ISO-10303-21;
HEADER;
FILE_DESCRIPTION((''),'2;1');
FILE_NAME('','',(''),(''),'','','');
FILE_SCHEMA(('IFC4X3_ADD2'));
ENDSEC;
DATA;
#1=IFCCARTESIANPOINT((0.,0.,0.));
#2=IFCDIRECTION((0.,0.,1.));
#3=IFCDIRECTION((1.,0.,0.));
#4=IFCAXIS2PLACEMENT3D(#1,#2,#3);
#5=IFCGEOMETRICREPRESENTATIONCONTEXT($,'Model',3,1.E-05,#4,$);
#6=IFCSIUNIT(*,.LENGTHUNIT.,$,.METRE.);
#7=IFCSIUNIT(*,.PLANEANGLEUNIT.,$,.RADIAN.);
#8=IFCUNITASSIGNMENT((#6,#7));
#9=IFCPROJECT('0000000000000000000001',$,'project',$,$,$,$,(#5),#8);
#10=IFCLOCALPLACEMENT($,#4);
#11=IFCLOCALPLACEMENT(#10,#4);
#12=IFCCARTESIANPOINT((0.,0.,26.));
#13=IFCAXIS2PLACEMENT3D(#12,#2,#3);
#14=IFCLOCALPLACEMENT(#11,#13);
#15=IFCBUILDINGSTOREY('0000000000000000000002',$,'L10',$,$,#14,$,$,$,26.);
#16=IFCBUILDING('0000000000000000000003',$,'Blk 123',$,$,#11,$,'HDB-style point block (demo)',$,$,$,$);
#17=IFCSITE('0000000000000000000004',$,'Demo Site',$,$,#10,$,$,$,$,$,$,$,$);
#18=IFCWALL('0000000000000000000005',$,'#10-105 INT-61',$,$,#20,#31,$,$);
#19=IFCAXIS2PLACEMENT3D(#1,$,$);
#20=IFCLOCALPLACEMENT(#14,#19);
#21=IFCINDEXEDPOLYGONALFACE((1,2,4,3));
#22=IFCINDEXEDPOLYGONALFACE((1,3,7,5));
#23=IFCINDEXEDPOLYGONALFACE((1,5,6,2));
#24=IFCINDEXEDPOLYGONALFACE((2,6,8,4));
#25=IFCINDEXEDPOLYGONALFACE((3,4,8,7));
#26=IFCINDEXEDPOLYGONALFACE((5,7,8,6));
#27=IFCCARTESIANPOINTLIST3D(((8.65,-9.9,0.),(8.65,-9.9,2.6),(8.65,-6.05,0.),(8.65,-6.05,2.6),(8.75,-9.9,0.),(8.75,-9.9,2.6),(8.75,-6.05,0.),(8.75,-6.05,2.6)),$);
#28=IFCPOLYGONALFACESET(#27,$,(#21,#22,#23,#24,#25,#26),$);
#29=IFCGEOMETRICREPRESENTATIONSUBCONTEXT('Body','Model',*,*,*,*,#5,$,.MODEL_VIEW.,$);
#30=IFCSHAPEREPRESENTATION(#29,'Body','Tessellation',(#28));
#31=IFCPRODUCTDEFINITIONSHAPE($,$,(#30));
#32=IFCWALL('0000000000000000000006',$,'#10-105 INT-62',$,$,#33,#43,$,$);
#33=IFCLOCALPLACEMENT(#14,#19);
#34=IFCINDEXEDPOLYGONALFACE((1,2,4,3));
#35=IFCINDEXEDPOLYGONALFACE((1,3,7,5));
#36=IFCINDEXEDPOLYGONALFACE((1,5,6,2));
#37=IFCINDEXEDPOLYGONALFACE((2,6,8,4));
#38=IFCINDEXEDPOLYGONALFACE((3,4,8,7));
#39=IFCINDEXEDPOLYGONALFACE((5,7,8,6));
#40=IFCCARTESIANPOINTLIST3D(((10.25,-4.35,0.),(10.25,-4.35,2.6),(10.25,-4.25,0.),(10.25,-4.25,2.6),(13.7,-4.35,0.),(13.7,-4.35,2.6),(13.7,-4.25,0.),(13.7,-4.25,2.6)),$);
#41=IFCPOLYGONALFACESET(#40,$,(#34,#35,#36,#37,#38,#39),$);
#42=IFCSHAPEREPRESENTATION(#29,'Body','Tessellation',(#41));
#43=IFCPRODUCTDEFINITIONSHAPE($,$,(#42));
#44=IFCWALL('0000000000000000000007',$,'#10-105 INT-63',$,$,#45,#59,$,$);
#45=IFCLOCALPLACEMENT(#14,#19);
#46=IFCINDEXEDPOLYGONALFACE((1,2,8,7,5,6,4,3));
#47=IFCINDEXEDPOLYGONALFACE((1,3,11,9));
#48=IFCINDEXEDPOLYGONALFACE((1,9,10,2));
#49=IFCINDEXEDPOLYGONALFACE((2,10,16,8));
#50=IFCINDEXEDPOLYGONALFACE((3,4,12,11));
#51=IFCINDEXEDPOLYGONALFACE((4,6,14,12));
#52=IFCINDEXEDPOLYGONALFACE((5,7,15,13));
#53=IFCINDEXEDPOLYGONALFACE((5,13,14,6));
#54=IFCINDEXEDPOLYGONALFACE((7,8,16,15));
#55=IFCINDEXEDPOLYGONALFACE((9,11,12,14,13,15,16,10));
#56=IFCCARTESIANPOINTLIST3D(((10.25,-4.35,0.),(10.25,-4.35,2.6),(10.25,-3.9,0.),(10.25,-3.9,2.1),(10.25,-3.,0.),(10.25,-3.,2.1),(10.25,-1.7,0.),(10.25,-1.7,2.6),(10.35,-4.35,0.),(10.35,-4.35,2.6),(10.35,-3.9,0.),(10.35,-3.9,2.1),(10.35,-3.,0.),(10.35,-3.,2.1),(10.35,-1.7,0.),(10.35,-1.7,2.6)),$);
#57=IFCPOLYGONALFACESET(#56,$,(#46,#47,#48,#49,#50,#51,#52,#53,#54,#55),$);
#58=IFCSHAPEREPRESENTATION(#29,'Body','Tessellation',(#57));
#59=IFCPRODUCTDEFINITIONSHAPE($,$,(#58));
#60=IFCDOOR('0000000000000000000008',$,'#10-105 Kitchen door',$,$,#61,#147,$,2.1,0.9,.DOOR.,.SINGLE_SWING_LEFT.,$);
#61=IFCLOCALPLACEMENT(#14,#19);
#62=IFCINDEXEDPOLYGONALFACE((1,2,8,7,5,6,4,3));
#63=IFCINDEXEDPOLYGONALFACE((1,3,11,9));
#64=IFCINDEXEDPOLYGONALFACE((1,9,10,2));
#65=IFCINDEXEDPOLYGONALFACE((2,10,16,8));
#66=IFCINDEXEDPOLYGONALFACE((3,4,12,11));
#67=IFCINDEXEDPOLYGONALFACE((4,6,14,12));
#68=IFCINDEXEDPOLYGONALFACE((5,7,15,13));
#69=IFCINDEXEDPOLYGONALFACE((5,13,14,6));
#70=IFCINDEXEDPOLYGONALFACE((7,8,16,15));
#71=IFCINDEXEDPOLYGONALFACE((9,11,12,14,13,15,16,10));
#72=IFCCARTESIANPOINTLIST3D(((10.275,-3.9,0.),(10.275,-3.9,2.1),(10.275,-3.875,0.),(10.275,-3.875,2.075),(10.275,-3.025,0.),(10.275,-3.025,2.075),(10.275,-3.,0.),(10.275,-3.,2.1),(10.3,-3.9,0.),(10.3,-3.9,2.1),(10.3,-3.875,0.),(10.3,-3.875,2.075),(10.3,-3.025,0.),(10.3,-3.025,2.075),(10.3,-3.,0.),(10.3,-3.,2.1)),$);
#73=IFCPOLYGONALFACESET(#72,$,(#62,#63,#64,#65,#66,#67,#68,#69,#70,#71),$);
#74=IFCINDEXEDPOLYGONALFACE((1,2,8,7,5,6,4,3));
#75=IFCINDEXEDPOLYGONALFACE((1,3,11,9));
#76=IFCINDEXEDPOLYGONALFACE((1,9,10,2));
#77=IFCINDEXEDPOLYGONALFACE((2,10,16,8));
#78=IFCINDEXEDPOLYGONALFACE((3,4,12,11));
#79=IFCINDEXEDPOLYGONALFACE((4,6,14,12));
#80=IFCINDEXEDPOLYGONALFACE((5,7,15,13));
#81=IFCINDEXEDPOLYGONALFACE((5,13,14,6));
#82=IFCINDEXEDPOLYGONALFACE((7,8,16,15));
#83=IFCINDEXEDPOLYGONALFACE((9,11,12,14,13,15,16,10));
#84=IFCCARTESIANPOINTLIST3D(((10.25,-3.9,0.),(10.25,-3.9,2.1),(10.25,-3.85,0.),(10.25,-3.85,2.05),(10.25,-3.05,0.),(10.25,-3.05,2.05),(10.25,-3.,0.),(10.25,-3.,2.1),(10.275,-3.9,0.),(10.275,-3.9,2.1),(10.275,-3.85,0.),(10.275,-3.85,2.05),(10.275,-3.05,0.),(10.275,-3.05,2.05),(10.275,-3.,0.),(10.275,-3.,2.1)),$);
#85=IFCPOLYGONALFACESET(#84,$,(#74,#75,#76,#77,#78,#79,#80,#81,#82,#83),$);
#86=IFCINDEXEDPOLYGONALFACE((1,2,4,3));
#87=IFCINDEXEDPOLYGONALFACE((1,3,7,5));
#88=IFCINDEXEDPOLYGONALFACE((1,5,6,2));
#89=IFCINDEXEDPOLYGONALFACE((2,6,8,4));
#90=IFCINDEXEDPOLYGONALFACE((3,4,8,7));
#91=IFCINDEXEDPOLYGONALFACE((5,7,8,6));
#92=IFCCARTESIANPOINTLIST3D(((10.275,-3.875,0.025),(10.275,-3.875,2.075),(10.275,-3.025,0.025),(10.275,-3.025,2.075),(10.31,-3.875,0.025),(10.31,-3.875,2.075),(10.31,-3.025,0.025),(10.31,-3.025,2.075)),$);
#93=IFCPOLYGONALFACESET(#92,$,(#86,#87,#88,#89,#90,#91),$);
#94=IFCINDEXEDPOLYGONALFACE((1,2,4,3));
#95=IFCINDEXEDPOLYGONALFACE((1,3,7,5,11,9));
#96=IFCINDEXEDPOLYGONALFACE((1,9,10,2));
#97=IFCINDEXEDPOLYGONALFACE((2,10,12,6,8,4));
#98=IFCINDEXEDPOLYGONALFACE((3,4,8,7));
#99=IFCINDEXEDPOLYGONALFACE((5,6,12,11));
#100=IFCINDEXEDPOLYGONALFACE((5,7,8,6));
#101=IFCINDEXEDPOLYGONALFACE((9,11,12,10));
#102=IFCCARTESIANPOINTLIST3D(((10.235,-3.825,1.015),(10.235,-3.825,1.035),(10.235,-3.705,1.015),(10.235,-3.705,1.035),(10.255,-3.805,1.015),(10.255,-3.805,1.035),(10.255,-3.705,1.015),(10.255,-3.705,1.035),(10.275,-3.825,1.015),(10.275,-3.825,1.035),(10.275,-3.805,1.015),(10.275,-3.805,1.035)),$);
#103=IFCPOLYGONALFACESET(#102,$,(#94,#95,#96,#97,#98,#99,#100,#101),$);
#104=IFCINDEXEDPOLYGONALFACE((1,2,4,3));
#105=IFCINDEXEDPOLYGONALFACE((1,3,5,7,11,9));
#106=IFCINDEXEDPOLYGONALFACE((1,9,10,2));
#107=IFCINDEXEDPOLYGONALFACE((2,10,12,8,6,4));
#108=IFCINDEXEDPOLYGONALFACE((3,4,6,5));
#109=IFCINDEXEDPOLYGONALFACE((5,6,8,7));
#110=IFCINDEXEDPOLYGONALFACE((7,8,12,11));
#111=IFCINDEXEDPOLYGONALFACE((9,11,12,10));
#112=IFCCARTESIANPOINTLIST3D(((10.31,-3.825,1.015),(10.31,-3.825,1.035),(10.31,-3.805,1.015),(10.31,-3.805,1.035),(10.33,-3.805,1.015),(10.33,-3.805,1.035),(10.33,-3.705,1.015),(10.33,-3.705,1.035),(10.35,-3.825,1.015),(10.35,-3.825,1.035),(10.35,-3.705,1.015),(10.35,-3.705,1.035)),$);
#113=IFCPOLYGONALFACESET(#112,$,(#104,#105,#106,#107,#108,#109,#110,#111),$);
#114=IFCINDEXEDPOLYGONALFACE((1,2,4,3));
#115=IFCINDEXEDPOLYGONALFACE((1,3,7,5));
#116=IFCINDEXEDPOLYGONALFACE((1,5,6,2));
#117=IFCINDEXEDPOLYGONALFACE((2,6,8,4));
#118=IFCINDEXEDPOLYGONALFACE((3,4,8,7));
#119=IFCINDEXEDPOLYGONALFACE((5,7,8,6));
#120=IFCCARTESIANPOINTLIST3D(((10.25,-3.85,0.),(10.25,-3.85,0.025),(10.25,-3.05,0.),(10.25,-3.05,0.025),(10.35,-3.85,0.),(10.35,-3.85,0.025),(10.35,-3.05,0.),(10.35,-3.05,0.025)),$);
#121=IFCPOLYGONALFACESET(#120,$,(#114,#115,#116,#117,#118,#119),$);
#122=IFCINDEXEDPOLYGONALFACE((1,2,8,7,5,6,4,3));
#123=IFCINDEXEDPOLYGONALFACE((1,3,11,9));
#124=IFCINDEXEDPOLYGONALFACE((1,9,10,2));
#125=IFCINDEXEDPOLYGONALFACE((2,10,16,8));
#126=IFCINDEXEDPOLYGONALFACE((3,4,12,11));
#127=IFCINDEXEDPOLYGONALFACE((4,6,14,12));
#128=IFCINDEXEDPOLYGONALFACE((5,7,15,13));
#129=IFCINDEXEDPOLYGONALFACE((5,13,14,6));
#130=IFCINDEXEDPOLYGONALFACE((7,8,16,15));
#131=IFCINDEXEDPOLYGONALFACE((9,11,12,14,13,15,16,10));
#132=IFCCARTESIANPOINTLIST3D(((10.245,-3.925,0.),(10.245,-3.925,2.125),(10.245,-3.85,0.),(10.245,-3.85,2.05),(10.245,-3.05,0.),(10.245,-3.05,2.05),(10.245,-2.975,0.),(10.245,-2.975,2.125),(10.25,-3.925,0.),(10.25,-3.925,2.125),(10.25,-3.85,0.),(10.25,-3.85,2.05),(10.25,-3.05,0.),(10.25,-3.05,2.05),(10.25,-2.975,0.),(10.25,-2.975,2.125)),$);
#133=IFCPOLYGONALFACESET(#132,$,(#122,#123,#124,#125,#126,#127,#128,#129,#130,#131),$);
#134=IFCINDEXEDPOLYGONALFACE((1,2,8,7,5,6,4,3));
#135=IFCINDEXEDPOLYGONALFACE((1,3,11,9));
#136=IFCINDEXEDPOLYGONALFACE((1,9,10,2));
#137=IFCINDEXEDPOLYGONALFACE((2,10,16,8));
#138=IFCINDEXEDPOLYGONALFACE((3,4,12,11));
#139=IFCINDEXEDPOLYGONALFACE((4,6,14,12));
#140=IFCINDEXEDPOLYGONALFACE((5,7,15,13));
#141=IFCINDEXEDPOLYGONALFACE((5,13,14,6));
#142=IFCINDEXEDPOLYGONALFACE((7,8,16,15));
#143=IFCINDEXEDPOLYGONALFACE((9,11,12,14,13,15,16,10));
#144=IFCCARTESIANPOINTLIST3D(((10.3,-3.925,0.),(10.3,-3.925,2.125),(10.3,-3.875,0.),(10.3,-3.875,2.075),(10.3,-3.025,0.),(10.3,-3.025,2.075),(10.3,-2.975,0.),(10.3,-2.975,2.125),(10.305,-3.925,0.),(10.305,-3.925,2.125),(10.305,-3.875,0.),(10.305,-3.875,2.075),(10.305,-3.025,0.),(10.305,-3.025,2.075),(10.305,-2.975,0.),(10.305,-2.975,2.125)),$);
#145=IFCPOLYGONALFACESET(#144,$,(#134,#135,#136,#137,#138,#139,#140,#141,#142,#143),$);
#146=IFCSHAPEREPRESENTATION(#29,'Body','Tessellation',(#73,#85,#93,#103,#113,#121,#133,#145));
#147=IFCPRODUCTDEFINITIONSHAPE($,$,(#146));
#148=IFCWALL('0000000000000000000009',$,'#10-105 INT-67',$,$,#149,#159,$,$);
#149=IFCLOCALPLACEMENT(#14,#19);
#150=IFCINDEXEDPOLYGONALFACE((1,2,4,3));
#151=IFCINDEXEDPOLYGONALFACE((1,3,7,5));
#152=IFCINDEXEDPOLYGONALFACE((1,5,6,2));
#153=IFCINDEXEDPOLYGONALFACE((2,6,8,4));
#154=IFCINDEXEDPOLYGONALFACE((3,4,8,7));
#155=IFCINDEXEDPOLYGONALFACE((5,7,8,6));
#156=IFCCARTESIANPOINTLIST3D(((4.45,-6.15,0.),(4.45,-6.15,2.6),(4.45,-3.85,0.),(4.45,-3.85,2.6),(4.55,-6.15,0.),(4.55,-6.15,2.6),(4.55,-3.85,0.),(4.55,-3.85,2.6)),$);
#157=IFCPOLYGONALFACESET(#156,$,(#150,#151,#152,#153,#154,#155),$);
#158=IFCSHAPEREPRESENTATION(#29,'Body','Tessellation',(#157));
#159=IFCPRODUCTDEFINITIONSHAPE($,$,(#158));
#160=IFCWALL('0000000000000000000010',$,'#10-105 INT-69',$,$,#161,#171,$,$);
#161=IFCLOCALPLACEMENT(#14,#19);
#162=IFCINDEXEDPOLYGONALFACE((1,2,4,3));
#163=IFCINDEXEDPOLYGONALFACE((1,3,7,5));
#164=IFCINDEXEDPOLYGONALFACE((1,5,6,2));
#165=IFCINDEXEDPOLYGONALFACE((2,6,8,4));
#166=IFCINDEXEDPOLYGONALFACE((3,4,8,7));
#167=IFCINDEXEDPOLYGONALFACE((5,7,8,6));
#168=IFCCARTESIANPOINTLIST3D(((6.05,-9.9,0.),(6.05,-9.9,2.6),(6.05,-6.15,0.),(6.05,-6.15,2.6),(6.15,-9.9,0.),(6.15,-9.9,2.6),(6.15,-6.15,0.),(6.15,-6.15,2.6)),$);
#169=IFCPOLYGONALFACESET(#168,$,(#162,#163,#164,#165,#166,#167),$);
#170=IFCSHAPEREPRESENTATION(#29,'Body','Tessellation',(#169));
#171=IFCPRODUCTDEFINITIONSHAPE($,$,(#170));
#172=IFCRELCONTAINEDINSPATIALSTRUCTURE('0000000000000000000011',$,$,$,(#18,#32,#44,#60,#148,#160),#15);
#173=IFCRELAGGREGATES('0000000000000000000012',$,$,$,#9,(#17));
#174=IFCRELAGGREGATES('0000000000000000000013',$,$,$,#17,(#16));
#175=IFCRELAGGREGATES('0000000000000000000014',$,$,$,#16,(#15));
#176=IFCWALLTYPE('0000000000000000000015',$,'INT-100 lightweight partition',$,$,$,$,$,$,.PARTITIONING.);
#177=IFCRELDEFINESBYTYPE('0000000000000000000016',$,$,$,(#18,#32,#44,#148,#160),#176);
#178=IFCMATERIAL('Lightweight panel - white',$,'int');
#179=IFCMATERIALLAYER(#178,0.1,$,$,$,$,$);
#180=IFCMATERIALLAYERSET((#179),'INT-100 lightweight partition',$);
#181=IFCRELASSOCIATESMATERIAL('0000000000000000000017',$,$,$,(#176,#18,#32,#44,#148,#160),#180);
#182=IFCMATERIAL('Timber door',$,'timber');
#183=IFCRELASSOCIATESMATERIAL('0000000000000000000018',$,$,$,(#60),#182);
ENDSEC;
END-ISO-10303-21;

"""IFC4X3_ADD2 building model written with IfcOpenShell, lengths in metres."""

from ifc_helpers import new_model, si_unit, frame, origin_with_axes, place, context, subcontext, project, spatial, line, indexed_curve, outline, extrude, material, layer, layer_set, layer_usage, type_object, element, fill, save


model = new_model("IFC4X3_ADD2")

# Units and contexts
model_context = context("Model", 3, precision=1e-05, world=origin_with_axes())
body_context = subcontext(model_context, "Body", "Model", "MODEL_VIEW")
ifc_project = project(units=[si_unit("LENGTHUNIT", "METRE"), si_unit("PLANEANGLEUNIT", "RADIAN")], contexts=[model_context])

# Site, building, storey
site_placement = place(None, origin_with_axes())
site = spatial("IfcSite", under=ifc_project, at=site_placement, Name="Demo Site")
building_placement = place(site_placement, origin_with_axes())
building = spatial("IfcBuilding", under=site, at=building_placement, Name="Blk 123", LongName="HDB-style point block (demo)")
storey_placement = place(building_placement, frame((0.0, 0.0, 26.0), z_axis=(0.0, 0.0, 1.0), x_axis=(1.0, 0.0, 0.0)))
storey = spatial("IfcBuildingStorey", under=building, at=storey_placement, Name="L10", Elevation=26.0)

# Walls
ifc_material_1 = material(Name="Lightweight panel - white", Category="int")
ifc_layer_1 = layer(ifc_material_1, 0.1)
ifc_layer_set_1 = layer_set([ifc_layer_1], Name="INT-100 lightweight partition")
ifc_layer_usage_1 = layer_usage(ifc_layer_set_1, "AXIS2", "POSITIVE", -0.05)
wall_type_1 = type_object("IfcWallType", Name="INT-100 lightweight partition", PredefinedType="PARTITIONING", material=ifc_layer_set_1)
wall_1_placement = place(storey_placement, frame((8.7, -6.05, 0.0), z_axis=(0.0, 0.0, 1.0), x_axis=(0.0, -1.0, 0.0)))
element("IfcWall", 1, at=wall_1_placement, inside=storey, type_object=wall_type_1, material=ifc_layer_usage_1, Name="#10-105 INT-61", context=body_context, shape_type="SweptSolid", body=[
    extrude(outline(indexed_curve([(0.0, 0.0), (0.0, 0.1), (3.85, 0.1), (3.85, 0.0), (0.0, 0.0)], self_intersect=False)), frame((0.0, -0.05, 0.0), z_axis=(0.0, 0.0, 1.0), x_axis=(1.0, 0.0, 0.0)), (0.0, 0.0, 1.0), 2.6),
])
wall_2_placement = place(storey_placement, frame((10.25, -4.3, 0.0), z_axis=(0.0, 0.0, 1.0), x_axis=(1.0, 0.0, 0.0)))
element("IfcWall", 2, at=wall_2_placement, inside=storey, type_object=wall_type_1, material=ifc_layer_usage_1, Name="#10-105 INT-62", context=body_context, shape_type="SweptSolid", body=[
    extrude(outline(indexed_curve([(0.0, 0.0), (0.0, 0.1), (3.45, 0.1), (3.45, 0.0), (0.0, 0.0)], self_intersect=False)), frame((0.0, -0.05, 0.0), z_axis=(0.0, 0.0, 1.0), x_axis=(1.0, 0.0, 0.0)), (0.0, 0.0, 1.0), 2.6),
])

# Wall, opening, door
wall_3_placement = place(storey_placement, frame((10.3, -1.7, 0.0), z_axis=(0.0, 0.0, 1.0), x_axis=(0.0, -1.0, 0.0)))
wall_3 = element("IfcWall", 3, at=wall_3_placement, inside=storey, type_object=wall_type_1, material=ifc_layer_usage_1, Name="#10-105 INT-63", context=body_context, shape_type="SweptSolid", body=[
    extrude(outline(indexed_curve([(0.0, 0.0), (0.0, 0.1), (2.65, 0.1), (2.65, 0.0), (0.0, 0.0)], self_intersect=False)), frame((0.0, -0.05, 0.0), z_axis=(0.0, 0.0, 1.0), x_axis=(1.0, 0.0, 0.0)), (0.0, 0.0, 1.0), 2.6),
])
opening_1_placement = place(wall_3_placement, frame((1.3, -0.15, 0.0), z_axis=(0.0, 0.0, 1.0), x_axis=(1.0, 0.0, 0.0)))
opening_1 = element("IfcOpeningElement", 4, at=opening_1_placement, cuts=wall_3, context=body_context, shape_type="SweptSolid", body=[
    extrude(outline(indexed_curve([(0.0, 0.0), (0.0, 0.3), (0.9, 0.3), (0.9, 0.0), (0.0, 0.0)], self_intersect=False)), origin_with_axes(), (0.0, 0.0, 1.0), 2.1),
])
ifc_material_2 = material(Name="Timber door", Category="timber")
door_1_placement = place(opening_1_placement, frame((0.0, 0.1, 0.0), z_axis=(0.0, 0.0, 1.0), x_axis=(1.0, 0.0, 0.0)))
door_1 = element("IfcDoor", 5, at=door_1_placement, inside=storey, material=ifc_material_2, Name="#10-105 Kitchen door", OperationType="SINGLE_SWING_LEFT", OverallHeight=2.1, OverallWidth=0.9, PredefinedType="DOOR", context=body_context, shape_type="SweptSolid", body=[
    extrude(outline(indexed_curve([(0.0, 0.0), (0.0, 2.1), (0.9, 2.1), (0.9, 0.0), (0.875, 0.0), (0.875, 2.075), (0.025, 2.075), (0.025, 0.0)], segments=[line(1, 2, 3, 4, 5, 6, 7, 8, 1)])), frame((0.0, 0.025, 0.0), z_axis=(0.0, -1.0, 0.0), x_axis=(1.0, 0.0, 0.0)), (0.0, 0.0, -1.0), 0.025),
    extrude(outline(indexed_curve([(0.0, 0.0), (0.0, 2.1), (0.9, 2.1), (0.9, 0.0), (0.85, 0.0), (0.85, 2.05), (0.05, 2.05), (0.05, 0.0)], segments=[line(1, 2, 3, 4, 5, 6, 7, 8, 1)])), frame((0.0, 0.0, 0.0), z_axis=(0.0, -1.0, 0.0), x_axis=(1.0, 0.0, 0.0)), (0.0, 0.0, -1.0), 0.025),
    extrude(outline(indexed_curve([(0.0, 0.0), (0.85, 0.0), (0.85, 0.035), (0.0, 0.035)], segments=[line(1, 2, 3, 4, 1)])), frame((0.025, 0.025, 0.025), z_axis=(0.0, 0.0, 1.0), x_axis=(1.0, 0.0, 0.0)), (0.0, 0.0, 1.0), 2.05),
    extrude(outline(indexed_curve([(0.0, 0.0), (0.0, -0.04), (-0.12, -0.04), (-0.12, -0.02), (-0.02, -0.02), (-0.02, 0.0)], segments=[line(1, 2, 3, 4, 5, 6, 1)])), frame((0.825, 0.025, 1.015), z_axis=(0.0, 0.0, 1.0), x_axis=(1.0, 0.0, 0.0)), (0.0, 0.0, 1.0), 0.02),
    extrude(outline(indexed_curve([(0.0, 0.0), (0.0, 0.04), (-0.12, 0.04), (-0.12, 0.02), (-0.02, 0.02), (-0.02, 0.0)], segments=[line(1, 2, 3, 4, 5, 6, 1)])), frame((0.825, 0.06, 1.015), z_axis=(0.0, 0.0, 1.0), x_axis=(1.0, 0.0, 0.0)), (0.0, 0.0, 1.0), 0.02),
    extrude(outline(indexed_curve([(0.0, 0.0), (0.8, 0.0), (0.8, 0.1), (0.0, 0.1)], segments=[line(1, 2, 3, 4, 1)])), frame((0.05, 0.0, 0.0), z_axis=(0.0, 0.0, 1.0), x_axis=(1.0, 0.0, 0.0)), (0.0, 0.0, 1.0), 0.025),
    extrude(outline(indexed_curve([(0.0, 0.0), (0.0, 2.125), (0.95, 2.125), (0.95, 0.0), (0.875, 0.0), (0.875, 2.05), (0.075, 2.05), (0.075, 0.0)], segments=[line(1, 2, 3, 4, 5, 6, 7, 8, 1)])), frame((-0.025, -0.005, 0.0), z_axis=(0.0, -1.0, 0.0), x_axis=(1.0, 0.0, 0.0)), (0.0, 0.0, -1.0), 0.005),
    extrude(outline(indexed_curve([(0.0, 0.0), (0.0, 2.125), (0.95, 2.125), (0.95, 0.0), (0.9, 0.0), (0.9, 2.075), (0.05, 2.075), (0.05, 0.0)], segments=[line(1, 2, 3, 4, 5, 6, 7, 8, 1)])), frame((-0.025, 0.05, 0.0), z_axis=(0.0, -1.0, 0.0), x_axis=(1.0, 0.0, 0.0)), (0.0, 0.0, -1.0), 0.005),
])
fill(opening_1, door_1)

# Walls
wall_4_placement = place(storey_placement, frame((4.5, -3.85, 0.0), z_axis=(0.0, 0.0, 1.0), x_axis=(0.0, -1.0, 0.0)))
element("IfcWall", 6, at=wall_4_placement, inside=storey, type_object=wall_type_1, material=ifc_layer_usage_1, Name="#10-105 INT-67", context=body_context, shape_type="SweptSolid", body=[
    extrude(outline(indexed_curve([(0.0, 0.0), (0.0, 0.1), (2.3, 0.1), (2.3, 0.0), (0.0, 0.0)], self_intersect=False)), frame((0.0, -0.05, 0.0), z_axis=(0.0, 0.0, 1.0), x_axis=(1.0, 0.0, 0.0)), (0.0, 0.0, 1.0), 2.6),
])
wall_5_placement = place(storey_placement, frame((6.1, -6.15, 0.0), z_axis=(0.0, 0.0, 1.0), x_axis=(0.0, -1.0, 0.0)))
element("IfcWall", 7, at=wall_5_placement, inside=storey, type_object=wall_type_1, material=ifc_layer_usage_1, Name="#10-105 INT-69", context=body_context, shape_type="SweptSolid", body=[
    extrude(outline(indexed_curve([(0.0, 0.0), (0.0, 0.1), (3.75, 0.1), (3.75, 0.0), (0.0, 0.0)], self_intersect=False)), frame((0.0, -0.05, 0.0), z_axis=(0.0, 0.0, 1.0), x_axis=(1.0, 0.0, 0.0)), (0.0, 0.0, 1.0), 2.6),
])

save(model, "model.ifc")
